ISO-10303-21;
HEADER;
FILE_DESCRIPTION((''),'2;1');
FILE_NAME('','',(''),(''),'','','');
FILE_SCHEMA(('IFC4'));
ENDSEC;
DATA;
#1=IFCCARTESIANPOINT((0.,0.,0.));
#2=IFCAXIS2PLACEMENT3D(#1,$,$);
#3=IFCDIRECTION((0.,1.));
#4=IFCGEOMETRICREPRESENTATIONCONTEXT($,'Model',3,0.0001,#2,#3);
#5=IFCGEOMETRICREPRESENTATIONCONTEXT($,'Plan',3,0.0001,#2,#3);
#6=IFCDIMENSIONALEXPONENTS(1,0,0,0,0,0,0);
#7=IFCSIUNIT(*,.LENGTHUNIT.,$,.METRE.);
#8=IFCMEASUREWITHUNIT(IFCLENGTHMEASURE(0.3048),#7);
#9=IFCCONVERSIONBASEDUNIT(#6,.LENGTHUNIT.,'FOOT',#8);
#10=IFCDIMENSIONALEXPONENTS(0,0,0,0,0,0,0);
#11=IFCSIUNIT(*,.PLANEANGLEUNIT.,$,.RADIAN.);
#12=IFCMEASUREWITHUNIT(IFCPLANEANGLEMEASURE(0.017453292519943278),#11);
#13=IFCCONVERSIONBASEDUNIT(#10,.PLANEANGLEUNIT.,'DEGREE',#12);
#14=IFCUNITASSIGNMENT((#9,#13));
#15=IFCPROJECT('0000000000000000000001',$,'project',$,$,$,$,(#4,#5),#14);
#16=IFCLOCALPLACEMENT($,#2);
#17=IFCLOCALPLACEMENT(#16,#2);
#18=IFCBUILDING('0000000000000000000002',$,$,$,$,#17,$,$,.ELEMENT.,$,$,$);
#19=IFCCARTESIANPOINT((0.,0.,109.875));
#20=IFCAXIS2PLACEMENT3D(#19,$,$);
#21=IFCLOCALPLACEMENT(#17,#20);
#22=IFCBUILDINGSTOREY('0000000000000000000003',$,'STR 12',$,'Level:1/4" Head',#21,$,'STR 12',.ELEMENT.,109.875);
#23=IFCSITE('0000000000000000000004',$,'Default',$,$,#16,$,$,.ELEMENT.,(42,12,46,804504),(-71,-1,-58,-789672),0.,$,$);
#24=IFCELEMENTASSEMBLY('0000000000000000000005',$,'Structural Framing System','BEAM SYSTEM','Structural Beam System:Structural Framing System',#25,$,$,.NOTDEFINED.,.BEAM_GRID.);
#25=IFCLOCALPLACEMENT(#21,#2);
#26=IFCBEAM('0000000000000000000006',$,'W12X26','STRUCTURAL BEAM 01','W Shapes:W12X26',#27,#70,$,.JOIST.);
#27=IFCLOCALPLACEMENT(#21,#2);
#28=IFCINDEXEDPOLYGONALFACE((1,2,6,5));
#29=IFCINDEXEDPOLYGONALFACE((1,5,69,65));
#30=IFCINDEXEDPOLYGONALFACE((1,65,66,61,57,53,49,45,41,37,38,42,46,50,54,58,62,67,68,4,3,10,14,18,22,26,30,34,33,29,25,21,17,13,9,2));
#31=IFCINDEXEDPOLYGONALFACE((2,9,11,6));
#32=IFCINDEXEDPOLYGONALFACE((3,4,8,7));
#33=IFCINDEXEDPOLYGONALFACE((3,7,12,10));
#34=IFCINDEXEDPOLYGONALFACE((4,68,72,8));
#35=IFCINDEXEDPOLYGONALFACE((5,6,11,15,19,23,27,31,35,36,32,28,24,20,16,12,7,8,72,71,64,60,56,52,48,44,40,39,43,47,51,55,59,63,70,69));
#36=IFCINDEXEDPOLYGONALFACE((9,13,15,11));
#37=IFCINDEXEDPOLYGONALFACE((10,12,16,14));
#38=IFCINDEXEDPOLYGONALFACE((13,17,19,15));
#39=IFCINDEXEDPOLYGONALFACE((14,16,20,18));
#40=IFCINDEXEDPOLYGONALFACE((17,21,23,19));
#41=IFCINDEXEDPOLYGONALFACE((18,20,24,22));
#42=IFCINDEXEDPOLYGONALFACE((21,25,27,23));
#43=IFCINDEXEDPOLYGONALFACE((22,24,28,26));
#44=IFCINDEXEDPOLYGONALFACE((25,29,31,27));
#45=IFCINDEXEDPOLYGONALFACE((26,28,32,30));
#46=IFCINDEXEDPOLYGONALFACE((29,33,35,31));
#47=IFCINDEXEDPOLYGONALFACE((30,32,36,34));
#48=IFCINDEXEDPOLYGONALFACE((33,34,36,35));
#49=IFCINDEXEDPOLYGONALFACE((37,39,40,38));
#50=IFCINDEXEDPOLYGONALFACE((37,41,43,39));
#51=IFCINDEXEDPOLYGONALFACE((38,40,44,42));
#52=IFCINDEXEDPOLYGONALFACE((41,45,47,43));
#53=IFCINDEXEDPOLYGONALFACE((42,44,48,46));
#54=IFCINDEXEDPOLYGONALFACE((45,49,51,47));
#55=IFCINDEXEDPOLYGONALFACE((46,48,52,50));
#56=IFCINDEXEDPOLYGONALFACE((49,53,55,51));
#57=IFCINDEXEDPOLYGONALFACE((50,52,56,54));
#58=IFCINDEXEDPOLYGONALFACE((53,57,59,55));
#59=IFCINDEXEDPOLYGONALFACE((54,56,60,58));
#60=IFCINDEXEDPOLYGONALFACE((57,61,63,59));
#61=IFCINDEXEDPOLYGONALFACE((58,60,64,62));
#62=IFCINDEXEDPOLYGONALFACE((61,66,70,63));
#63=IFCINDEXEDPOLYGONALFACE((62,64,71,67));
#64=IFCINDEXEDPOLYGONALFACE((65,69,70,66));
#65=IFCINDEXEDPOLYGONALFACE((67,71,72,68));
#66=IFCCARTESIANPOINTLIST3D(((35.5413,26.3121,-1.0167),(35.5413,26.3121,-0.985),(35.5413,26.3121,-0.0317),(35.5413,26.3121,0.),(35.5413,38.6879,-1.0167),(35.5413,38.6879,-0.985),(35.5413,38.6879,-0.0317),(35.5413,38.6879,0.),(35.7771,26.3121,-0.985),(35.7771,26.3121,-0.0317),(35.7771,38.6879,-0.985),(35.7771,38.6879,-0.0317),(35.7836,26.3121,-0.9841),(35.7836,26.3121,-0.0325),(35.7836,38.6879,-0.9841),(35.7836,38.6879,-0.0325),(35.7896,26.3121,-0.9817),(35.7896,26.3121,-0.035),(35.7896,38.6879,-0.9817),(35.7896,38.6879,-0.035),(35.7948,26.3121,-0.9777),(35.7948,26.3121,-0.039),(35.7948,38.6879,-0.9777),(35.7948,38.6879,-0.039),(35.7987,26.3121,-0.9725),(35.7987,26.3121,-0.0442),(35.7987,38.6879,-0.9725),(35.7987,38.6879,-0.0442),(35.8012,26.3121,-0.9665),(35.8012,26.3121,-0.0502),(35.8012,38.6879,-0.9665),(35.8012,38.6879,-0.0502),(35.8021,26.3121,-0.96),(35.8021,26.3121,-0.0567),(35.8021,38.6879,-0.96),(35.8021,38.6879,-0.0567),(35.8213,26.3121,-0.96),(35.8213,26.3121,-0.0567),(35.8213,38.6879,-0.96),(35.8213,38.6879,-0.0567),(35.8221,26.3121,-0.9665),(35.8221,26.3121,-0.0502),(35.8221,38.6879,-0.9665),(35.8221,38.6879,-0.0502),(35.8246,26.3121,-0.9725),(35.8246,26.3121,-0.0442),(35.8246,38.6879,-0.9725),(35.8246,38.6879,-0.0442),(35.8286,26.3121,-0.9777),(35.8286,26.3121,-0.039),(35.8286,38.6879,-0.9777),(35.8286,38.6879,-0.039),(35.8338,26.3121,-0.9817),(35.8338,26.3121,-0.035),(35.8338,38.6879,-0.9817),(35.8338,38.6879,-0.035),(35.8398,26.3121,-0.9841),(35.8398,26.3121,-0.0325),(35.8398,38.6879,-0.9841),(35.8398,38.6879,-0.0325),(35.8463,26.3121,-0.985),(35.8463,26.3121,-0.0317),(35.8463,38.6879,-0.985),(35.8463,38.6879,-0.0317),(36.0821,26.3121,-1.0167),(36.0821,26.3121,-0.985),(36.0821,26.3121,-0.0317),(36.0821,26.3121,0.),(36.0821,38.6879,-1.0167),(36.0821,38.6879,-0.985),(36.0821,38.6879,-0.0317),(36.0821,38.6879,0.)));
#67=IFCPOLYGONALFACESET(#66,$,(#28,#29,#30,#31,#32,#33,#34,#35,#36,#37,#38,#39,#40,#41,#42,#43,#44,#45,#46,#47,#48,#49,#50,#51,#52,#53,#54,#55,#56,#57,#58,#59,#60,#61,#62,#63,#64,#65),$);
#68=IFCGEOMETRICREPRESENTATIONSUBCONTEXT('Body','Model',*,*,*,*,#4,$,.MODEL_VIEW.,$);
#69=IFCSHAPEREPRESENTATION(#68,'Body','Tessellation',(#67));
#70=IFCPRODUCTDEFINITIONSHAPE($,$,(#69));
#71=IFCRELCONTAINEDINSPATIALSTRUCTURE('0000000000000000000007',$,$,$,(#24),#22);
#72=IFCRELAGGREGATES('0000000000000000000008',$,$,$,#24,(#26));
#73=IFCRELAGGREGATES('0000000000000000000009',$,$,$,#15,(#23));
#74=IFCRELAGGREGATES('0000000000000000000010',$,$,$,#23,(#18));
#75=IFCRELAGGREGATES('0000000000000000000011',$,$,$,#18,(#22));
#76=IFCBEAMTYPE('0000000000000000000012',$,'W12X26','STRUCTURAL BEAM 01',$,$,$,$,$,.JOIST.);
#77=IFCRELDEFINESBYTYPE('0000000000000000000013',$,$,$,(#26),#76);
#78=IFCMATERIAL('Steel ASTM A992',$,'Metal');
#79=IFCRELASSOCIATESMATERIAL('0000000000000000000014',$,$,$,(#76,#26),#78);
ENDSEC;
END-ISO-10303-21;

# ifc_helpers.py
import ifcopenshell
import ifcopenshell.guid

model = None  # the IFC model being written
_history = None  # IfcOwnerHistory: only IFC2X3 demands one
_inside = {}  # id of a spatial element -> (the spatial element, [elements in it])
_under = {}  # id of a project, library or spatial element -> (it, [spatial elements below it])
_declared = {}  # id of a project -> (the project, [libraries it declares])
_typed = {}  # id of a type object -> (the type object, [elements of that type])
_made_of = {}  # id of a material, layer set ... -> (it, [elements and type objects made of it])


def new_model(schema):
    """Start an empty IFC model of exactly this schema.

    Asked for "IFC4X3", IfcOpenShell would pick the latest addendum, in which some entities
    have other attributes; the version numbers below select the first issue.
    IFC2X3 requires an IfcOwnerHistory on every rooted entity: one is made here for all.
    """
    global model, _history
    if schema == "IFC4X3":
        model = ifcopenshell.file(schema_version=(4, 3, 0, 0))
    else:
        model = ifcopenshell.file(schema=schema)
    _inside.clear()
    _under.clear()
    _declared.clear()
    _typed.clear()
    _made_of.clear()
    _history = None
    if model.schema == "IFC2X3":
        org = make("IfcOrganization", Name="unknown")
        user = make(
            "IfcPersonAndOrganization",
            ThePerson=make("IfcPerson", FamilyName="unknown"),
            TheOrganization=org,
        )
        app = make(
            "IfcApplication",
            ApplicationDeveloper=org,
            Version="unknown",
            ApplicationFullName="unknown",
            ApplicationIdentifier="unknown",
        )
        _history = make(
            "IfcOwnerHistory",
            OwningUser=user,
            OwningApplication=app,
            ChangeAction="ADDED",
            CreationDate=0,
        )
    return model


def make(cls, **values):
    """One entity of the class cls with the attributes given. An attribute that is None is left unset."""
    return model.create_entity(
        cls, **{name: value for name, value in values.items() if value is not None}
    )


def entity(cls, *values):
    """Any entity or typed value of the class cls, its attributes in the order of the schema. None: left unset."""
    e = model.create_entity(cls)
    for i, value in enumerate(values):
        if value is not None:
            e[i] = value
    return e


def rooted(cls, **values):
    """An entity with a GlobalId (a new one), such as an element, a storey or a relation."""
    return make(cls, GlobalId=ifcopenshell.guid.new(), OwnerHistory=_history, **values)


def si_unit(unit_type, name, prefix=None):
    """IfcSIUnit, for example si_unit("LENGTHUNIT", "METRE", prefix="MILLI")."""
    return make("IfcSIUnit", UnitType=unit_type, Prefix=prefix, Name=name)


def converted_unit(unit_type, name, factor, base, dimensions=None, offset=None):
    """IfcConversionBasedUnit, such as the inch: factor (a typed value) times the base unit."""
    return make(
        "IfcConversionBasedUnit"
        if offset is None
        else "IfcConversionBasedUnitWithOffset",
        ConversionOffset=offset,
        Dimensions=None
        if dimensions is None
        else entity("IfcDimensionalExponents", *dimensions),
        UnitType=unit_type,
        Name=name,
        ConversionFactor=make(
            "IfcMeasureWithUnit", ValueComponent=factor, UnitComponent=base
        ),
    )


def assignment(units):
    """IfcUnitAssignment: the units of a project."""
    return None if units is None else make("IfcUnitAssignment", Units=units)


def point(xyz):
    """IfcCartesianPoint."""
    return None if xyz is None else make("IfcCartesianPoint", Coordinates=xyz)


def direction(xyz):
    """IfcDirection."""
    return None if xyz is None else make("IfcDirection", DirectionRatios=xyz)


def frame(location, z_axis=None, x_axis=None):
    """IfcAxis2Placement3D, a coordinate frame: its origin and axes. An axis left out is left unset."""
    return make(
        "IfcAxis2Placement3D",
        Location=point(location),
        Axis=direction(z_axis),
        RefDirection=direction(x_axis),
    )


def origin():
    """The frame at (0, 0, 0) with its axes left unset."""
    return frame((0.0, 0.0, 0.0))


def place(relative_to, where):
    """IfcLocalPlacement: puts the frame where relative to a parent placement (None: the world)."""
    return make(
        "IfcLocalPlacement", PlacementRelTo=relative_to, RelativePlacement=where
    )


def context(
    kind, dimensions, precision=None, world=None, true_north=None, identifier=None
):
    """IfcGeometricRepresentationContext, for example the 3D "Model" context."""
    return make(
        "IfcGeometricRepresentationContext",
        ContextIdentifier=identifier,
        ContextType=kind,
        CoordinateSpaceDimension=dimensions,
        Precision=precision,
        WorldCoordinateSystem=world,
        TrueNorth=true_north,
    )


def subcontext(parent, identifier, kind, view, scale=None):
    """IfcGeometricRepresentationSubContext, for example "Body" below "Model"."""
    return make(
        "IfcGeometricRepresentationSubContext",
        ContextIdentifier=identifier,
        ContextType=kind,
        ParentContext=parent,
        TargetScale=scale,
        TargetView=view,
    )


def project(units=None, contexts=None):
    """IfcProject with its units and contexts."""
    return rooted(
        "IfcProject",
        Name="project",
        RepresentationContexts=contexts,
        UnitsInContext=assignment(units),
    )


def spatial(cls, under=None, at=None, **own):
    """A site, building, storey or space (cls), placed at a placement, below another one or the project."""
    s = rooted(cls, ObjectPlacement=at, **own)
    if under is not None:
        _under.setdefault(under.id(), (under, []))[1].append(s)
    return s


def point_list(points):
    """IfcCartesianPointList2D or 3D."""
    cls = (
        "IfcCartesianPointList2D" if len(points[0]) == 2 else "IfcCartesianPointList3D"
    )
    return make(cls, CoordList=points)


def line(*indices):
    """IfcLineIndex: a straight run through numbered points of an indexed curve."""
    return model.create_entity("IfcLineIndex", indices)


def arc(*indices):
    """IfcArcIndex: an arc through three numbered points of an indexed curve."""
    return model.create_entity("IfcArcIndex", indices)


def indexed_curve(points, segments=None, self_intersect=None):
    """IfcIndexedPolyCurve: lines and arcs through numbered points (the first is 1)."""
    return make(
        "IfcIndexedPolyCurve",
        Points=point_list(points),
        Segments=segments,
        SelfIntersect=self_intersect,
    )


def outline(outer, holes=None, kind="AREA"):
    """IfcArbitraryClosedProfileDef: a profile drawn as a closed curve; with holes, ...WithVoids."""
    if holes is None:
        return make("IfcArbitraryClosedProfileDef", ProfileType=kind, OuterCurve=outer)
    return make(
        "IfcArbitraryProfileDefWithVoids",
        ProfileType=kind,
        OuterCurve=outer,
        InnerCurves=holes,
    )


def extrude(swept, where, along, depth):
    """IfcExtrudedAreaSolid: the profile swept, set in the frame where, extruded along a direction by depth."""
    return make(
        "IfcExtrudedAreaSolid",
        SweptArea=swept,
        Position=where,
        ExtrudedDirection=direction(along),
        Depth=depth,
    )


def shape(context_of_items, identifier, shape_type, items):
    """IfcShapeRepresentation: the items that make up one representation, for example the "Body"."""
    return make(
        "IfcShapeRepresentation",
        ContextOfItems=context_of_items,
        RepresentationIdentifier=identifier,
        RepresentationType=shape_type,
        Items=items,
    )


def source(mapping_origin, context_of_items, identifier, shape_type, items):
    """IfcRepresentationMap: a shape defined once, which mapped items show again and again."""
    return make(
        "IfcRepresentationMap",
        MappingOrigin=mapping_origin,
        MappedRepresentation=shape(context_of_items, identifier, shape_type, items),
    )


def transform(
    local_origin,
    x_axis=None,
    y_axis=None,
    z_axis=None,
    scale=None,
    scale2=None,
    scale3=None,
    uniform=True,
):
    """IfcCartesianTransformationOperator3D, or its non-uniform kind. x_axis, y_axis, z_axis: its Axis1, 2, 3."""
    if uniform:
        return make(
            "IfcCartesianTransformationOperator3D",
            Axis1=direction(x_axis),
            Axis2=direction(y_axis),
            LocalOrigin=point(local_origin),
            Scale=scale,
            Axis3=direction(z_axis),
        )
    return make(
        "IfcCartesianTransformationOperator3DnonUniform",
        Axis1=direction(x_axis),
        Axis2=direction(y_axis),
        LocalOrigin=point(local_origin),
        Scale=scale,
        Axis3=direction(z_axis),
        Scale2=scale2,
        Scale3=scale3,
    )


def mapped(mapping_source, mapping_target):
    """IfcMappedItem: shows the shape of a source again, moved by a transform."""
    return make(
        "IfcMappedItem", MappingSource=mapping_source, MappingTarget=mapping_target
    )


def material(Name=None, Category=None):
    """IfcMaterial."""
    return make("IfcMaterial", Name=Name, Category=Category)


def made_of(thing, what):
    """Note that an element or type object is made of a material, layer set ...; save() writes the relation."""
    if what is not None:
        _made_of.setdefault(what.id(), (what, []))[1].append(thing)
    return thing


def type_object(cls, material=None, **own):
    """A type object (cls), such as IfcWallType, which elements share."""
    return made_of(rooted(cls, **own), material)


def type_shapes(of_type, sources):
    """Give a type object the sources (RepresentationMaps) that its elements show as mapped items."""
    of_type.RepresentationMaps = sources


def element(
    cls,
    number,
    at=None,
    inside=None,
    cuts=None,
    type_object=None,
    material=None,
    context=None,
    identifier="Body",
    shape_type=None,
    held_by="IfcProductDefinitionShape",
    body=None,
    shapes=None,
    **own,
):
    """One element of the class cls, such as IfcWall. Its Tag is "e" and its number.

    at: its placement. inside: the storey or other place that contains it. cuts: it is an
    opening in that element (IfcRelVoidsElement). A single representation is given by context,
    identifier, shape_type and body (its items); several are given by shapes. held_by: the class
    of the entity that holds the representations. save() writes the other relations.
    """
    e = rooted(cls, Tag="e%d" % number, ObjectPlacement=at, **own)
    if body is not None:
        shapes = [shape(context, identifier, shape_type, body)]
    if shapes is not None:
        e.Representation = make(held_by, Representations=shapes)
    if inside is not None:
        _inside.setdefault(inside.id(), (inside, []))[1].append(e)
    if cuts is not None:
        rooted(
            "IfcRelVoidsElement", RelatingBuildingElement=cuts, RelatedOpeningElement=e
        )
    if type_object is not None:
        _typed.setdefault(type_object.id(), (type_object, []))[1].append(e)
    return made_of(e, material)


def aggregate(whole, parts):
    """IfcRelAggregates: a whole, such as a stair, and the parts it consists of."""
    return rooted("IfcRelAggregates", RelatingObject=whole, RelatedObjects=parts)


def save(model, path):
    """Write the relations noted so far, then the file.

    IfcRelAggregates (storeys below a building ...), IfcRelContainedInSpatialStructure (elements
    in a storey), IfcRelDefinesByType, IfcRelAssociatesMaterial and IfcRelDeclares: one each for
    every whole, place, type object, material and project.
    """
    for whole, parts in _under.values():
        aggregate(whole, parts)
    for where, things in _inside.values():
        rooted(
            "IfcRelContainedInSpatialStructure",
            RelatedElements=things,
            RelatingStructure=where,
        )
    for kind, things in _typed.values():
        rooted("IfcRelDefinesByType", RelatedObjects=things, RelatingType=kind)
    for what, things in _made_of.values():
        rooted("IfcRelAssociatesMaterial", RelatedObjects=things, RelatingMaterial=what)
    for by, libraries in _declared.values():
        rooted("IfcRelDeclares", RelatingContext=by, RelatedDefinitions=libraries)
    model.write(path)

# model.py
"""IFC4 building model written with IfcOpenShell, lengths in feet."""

from ifc_helpers import new_model, entity, si_unit, converted_unit, direction, frame, origin, place, context, subcontext, project, spatial, line, arc, indexed_curve, outline, extrude, source, transform, mapped, material, type_object, type_shapes, element, aggregate, save


model = new_model("IFC4")

# Units and contexts
model_context = context("Model", 3, precision=0.0001, world=origin(), true_north=direction((0.0, 1.0)))
plan_context = context("Plan", 3, precision=0.0001, world=origin(), true_north=direction((0.0, 1.0)))
body_context = subcontext(model_context, "Body", "Model", "MODEL_VIEW")
ifc_project = project(units=[converted_unit("LENGTHUNIT", "FOOT", entity("IfcLengthMeasure", 0.3048), si_unit("LENGTHUNIT", "METRE"), dimensions=[1, 0, 0, 0, 0, 0, 0]), converted_unit("PLANEANGLEUNIT", "DEGREE", entity("IfcPlaneAngleMeasure", 0.017453292519943278), si_unit("PLANEANGLEUNIT", "RADIAN"), dimensions=[0, 0, 0, 0, 0, 0, 0])], contexts=[model_context, plan_context])

# Site, building, storey
site_placement = place(None, origin())
site = spatial("IfcSite", under=ifc_project, at=site_placement, Name="Default", CompositionType="ELEMENT", RefLatitude=(42, 12, 46, 804504), RefLongitude=(-71, -1, -58, -789672), RefElevation=0.0)
building_placement = place(site_placement, origin())
building = spatial("IfcBuilding", under=site, at=building_placement, CompositionType="ELEMENT")
storey_placement = place(building_placement, frame((0.0, 0.0, 109.875)))
storey = spatial("IfcBuildingStorey", under=building, at=storey_placement, Name="STR 12", ObjectType="Level:1/4\" Head", LongName="STR 12", CompositionType="ELEMENT", Elevation=109.875)

# Element assembly, beam
ifc_material = material(Name="Steel ASTM A992", Category="Metal")
beam_type = type_object("IfcBeamType", Name="W12X26", Description="STRUCTURAL BEAM 01", PredefinedType="JOIST", material=ifc_material)
shared_shape = source(origin(), body_context, "Body", "SweptSolid", [
    extrude(outline(indexed_curve([(-0.2704, -0.4767), (-0.2704, -0.5083), (0.2704, -0.5083), (0.2704, -0.4767), (0.0346, -0.4767), (0.0169, -0.4693), (0.0096, -0.4517), (0.0096, 0.4517), (0.0169, 0.4693), (0.0346, 0.4767), (0.2704, 0.4767), (0.2704, 0.5083), (-0.2704, 0.5083), (-0.2704, 0.4767), (-0.0346, 0.4767), (-0.0169, 0.4693), (-0.0096, 0.4517), (-0.0096, -0.4517), (-0.0169, -0.4693), (-0.0346, -0.4767)], segments=[line(1, 2, 3, 4, 5), arc(5, 6, 7), line(7, 8), arc(8, 9, 10), line(10, 11, 12, 13, 14, 15), arc(15, 16, 17), line(17, 18), arc(18, 19, 20), line(20, 1)], self_intersect=False)), frame((-6.1879, 0.0, 0.0), z_axis=(-1.0, 0.0, 0.0), x_axis=(0.0, -1.0, 0.0)), (0.0, 0.0, -1.0), 12.3758),
])
type_shapes(beam_type, [shared_shape])
assembly_1_placement = place(storey_placement, origin())
assembly_1 = element("IfcElementAssembly", 1, at=assembly_1_placement, inside=storey, Name="Structural Framing System", Description="BEAM SYSTEM", ObjectType="Structural Beam System:Structural Framing System", AssemblyPlace="NOTDEFINED", PredefinedType="BEAM_GRID")
beam_1_placement = place(assembly_1_placement, frame((35.8117, 32.5, -0.5083), z_axis=(0.0, 0.0, 1.0), x_axis=(0.0, 1.0, 0.0)))
beam_1 = element("IfcBeam", 2, at=beam_1_placement, type_object=beam_type, material=ifc_material, Name="W12X26", Description="STRUCTURAL BEAM 01", ObjectType="W Shapes:W12X26", PredefinedType="JOIST", context=body_context, shape_type="MappedRepresentation", body=[
    mapped(shared_shape, transform((0.0, 0.0, 0.0), scale=1.0)),
])
aggregate(assembly_1, [beam_1])

save(model, "model.ifc")
